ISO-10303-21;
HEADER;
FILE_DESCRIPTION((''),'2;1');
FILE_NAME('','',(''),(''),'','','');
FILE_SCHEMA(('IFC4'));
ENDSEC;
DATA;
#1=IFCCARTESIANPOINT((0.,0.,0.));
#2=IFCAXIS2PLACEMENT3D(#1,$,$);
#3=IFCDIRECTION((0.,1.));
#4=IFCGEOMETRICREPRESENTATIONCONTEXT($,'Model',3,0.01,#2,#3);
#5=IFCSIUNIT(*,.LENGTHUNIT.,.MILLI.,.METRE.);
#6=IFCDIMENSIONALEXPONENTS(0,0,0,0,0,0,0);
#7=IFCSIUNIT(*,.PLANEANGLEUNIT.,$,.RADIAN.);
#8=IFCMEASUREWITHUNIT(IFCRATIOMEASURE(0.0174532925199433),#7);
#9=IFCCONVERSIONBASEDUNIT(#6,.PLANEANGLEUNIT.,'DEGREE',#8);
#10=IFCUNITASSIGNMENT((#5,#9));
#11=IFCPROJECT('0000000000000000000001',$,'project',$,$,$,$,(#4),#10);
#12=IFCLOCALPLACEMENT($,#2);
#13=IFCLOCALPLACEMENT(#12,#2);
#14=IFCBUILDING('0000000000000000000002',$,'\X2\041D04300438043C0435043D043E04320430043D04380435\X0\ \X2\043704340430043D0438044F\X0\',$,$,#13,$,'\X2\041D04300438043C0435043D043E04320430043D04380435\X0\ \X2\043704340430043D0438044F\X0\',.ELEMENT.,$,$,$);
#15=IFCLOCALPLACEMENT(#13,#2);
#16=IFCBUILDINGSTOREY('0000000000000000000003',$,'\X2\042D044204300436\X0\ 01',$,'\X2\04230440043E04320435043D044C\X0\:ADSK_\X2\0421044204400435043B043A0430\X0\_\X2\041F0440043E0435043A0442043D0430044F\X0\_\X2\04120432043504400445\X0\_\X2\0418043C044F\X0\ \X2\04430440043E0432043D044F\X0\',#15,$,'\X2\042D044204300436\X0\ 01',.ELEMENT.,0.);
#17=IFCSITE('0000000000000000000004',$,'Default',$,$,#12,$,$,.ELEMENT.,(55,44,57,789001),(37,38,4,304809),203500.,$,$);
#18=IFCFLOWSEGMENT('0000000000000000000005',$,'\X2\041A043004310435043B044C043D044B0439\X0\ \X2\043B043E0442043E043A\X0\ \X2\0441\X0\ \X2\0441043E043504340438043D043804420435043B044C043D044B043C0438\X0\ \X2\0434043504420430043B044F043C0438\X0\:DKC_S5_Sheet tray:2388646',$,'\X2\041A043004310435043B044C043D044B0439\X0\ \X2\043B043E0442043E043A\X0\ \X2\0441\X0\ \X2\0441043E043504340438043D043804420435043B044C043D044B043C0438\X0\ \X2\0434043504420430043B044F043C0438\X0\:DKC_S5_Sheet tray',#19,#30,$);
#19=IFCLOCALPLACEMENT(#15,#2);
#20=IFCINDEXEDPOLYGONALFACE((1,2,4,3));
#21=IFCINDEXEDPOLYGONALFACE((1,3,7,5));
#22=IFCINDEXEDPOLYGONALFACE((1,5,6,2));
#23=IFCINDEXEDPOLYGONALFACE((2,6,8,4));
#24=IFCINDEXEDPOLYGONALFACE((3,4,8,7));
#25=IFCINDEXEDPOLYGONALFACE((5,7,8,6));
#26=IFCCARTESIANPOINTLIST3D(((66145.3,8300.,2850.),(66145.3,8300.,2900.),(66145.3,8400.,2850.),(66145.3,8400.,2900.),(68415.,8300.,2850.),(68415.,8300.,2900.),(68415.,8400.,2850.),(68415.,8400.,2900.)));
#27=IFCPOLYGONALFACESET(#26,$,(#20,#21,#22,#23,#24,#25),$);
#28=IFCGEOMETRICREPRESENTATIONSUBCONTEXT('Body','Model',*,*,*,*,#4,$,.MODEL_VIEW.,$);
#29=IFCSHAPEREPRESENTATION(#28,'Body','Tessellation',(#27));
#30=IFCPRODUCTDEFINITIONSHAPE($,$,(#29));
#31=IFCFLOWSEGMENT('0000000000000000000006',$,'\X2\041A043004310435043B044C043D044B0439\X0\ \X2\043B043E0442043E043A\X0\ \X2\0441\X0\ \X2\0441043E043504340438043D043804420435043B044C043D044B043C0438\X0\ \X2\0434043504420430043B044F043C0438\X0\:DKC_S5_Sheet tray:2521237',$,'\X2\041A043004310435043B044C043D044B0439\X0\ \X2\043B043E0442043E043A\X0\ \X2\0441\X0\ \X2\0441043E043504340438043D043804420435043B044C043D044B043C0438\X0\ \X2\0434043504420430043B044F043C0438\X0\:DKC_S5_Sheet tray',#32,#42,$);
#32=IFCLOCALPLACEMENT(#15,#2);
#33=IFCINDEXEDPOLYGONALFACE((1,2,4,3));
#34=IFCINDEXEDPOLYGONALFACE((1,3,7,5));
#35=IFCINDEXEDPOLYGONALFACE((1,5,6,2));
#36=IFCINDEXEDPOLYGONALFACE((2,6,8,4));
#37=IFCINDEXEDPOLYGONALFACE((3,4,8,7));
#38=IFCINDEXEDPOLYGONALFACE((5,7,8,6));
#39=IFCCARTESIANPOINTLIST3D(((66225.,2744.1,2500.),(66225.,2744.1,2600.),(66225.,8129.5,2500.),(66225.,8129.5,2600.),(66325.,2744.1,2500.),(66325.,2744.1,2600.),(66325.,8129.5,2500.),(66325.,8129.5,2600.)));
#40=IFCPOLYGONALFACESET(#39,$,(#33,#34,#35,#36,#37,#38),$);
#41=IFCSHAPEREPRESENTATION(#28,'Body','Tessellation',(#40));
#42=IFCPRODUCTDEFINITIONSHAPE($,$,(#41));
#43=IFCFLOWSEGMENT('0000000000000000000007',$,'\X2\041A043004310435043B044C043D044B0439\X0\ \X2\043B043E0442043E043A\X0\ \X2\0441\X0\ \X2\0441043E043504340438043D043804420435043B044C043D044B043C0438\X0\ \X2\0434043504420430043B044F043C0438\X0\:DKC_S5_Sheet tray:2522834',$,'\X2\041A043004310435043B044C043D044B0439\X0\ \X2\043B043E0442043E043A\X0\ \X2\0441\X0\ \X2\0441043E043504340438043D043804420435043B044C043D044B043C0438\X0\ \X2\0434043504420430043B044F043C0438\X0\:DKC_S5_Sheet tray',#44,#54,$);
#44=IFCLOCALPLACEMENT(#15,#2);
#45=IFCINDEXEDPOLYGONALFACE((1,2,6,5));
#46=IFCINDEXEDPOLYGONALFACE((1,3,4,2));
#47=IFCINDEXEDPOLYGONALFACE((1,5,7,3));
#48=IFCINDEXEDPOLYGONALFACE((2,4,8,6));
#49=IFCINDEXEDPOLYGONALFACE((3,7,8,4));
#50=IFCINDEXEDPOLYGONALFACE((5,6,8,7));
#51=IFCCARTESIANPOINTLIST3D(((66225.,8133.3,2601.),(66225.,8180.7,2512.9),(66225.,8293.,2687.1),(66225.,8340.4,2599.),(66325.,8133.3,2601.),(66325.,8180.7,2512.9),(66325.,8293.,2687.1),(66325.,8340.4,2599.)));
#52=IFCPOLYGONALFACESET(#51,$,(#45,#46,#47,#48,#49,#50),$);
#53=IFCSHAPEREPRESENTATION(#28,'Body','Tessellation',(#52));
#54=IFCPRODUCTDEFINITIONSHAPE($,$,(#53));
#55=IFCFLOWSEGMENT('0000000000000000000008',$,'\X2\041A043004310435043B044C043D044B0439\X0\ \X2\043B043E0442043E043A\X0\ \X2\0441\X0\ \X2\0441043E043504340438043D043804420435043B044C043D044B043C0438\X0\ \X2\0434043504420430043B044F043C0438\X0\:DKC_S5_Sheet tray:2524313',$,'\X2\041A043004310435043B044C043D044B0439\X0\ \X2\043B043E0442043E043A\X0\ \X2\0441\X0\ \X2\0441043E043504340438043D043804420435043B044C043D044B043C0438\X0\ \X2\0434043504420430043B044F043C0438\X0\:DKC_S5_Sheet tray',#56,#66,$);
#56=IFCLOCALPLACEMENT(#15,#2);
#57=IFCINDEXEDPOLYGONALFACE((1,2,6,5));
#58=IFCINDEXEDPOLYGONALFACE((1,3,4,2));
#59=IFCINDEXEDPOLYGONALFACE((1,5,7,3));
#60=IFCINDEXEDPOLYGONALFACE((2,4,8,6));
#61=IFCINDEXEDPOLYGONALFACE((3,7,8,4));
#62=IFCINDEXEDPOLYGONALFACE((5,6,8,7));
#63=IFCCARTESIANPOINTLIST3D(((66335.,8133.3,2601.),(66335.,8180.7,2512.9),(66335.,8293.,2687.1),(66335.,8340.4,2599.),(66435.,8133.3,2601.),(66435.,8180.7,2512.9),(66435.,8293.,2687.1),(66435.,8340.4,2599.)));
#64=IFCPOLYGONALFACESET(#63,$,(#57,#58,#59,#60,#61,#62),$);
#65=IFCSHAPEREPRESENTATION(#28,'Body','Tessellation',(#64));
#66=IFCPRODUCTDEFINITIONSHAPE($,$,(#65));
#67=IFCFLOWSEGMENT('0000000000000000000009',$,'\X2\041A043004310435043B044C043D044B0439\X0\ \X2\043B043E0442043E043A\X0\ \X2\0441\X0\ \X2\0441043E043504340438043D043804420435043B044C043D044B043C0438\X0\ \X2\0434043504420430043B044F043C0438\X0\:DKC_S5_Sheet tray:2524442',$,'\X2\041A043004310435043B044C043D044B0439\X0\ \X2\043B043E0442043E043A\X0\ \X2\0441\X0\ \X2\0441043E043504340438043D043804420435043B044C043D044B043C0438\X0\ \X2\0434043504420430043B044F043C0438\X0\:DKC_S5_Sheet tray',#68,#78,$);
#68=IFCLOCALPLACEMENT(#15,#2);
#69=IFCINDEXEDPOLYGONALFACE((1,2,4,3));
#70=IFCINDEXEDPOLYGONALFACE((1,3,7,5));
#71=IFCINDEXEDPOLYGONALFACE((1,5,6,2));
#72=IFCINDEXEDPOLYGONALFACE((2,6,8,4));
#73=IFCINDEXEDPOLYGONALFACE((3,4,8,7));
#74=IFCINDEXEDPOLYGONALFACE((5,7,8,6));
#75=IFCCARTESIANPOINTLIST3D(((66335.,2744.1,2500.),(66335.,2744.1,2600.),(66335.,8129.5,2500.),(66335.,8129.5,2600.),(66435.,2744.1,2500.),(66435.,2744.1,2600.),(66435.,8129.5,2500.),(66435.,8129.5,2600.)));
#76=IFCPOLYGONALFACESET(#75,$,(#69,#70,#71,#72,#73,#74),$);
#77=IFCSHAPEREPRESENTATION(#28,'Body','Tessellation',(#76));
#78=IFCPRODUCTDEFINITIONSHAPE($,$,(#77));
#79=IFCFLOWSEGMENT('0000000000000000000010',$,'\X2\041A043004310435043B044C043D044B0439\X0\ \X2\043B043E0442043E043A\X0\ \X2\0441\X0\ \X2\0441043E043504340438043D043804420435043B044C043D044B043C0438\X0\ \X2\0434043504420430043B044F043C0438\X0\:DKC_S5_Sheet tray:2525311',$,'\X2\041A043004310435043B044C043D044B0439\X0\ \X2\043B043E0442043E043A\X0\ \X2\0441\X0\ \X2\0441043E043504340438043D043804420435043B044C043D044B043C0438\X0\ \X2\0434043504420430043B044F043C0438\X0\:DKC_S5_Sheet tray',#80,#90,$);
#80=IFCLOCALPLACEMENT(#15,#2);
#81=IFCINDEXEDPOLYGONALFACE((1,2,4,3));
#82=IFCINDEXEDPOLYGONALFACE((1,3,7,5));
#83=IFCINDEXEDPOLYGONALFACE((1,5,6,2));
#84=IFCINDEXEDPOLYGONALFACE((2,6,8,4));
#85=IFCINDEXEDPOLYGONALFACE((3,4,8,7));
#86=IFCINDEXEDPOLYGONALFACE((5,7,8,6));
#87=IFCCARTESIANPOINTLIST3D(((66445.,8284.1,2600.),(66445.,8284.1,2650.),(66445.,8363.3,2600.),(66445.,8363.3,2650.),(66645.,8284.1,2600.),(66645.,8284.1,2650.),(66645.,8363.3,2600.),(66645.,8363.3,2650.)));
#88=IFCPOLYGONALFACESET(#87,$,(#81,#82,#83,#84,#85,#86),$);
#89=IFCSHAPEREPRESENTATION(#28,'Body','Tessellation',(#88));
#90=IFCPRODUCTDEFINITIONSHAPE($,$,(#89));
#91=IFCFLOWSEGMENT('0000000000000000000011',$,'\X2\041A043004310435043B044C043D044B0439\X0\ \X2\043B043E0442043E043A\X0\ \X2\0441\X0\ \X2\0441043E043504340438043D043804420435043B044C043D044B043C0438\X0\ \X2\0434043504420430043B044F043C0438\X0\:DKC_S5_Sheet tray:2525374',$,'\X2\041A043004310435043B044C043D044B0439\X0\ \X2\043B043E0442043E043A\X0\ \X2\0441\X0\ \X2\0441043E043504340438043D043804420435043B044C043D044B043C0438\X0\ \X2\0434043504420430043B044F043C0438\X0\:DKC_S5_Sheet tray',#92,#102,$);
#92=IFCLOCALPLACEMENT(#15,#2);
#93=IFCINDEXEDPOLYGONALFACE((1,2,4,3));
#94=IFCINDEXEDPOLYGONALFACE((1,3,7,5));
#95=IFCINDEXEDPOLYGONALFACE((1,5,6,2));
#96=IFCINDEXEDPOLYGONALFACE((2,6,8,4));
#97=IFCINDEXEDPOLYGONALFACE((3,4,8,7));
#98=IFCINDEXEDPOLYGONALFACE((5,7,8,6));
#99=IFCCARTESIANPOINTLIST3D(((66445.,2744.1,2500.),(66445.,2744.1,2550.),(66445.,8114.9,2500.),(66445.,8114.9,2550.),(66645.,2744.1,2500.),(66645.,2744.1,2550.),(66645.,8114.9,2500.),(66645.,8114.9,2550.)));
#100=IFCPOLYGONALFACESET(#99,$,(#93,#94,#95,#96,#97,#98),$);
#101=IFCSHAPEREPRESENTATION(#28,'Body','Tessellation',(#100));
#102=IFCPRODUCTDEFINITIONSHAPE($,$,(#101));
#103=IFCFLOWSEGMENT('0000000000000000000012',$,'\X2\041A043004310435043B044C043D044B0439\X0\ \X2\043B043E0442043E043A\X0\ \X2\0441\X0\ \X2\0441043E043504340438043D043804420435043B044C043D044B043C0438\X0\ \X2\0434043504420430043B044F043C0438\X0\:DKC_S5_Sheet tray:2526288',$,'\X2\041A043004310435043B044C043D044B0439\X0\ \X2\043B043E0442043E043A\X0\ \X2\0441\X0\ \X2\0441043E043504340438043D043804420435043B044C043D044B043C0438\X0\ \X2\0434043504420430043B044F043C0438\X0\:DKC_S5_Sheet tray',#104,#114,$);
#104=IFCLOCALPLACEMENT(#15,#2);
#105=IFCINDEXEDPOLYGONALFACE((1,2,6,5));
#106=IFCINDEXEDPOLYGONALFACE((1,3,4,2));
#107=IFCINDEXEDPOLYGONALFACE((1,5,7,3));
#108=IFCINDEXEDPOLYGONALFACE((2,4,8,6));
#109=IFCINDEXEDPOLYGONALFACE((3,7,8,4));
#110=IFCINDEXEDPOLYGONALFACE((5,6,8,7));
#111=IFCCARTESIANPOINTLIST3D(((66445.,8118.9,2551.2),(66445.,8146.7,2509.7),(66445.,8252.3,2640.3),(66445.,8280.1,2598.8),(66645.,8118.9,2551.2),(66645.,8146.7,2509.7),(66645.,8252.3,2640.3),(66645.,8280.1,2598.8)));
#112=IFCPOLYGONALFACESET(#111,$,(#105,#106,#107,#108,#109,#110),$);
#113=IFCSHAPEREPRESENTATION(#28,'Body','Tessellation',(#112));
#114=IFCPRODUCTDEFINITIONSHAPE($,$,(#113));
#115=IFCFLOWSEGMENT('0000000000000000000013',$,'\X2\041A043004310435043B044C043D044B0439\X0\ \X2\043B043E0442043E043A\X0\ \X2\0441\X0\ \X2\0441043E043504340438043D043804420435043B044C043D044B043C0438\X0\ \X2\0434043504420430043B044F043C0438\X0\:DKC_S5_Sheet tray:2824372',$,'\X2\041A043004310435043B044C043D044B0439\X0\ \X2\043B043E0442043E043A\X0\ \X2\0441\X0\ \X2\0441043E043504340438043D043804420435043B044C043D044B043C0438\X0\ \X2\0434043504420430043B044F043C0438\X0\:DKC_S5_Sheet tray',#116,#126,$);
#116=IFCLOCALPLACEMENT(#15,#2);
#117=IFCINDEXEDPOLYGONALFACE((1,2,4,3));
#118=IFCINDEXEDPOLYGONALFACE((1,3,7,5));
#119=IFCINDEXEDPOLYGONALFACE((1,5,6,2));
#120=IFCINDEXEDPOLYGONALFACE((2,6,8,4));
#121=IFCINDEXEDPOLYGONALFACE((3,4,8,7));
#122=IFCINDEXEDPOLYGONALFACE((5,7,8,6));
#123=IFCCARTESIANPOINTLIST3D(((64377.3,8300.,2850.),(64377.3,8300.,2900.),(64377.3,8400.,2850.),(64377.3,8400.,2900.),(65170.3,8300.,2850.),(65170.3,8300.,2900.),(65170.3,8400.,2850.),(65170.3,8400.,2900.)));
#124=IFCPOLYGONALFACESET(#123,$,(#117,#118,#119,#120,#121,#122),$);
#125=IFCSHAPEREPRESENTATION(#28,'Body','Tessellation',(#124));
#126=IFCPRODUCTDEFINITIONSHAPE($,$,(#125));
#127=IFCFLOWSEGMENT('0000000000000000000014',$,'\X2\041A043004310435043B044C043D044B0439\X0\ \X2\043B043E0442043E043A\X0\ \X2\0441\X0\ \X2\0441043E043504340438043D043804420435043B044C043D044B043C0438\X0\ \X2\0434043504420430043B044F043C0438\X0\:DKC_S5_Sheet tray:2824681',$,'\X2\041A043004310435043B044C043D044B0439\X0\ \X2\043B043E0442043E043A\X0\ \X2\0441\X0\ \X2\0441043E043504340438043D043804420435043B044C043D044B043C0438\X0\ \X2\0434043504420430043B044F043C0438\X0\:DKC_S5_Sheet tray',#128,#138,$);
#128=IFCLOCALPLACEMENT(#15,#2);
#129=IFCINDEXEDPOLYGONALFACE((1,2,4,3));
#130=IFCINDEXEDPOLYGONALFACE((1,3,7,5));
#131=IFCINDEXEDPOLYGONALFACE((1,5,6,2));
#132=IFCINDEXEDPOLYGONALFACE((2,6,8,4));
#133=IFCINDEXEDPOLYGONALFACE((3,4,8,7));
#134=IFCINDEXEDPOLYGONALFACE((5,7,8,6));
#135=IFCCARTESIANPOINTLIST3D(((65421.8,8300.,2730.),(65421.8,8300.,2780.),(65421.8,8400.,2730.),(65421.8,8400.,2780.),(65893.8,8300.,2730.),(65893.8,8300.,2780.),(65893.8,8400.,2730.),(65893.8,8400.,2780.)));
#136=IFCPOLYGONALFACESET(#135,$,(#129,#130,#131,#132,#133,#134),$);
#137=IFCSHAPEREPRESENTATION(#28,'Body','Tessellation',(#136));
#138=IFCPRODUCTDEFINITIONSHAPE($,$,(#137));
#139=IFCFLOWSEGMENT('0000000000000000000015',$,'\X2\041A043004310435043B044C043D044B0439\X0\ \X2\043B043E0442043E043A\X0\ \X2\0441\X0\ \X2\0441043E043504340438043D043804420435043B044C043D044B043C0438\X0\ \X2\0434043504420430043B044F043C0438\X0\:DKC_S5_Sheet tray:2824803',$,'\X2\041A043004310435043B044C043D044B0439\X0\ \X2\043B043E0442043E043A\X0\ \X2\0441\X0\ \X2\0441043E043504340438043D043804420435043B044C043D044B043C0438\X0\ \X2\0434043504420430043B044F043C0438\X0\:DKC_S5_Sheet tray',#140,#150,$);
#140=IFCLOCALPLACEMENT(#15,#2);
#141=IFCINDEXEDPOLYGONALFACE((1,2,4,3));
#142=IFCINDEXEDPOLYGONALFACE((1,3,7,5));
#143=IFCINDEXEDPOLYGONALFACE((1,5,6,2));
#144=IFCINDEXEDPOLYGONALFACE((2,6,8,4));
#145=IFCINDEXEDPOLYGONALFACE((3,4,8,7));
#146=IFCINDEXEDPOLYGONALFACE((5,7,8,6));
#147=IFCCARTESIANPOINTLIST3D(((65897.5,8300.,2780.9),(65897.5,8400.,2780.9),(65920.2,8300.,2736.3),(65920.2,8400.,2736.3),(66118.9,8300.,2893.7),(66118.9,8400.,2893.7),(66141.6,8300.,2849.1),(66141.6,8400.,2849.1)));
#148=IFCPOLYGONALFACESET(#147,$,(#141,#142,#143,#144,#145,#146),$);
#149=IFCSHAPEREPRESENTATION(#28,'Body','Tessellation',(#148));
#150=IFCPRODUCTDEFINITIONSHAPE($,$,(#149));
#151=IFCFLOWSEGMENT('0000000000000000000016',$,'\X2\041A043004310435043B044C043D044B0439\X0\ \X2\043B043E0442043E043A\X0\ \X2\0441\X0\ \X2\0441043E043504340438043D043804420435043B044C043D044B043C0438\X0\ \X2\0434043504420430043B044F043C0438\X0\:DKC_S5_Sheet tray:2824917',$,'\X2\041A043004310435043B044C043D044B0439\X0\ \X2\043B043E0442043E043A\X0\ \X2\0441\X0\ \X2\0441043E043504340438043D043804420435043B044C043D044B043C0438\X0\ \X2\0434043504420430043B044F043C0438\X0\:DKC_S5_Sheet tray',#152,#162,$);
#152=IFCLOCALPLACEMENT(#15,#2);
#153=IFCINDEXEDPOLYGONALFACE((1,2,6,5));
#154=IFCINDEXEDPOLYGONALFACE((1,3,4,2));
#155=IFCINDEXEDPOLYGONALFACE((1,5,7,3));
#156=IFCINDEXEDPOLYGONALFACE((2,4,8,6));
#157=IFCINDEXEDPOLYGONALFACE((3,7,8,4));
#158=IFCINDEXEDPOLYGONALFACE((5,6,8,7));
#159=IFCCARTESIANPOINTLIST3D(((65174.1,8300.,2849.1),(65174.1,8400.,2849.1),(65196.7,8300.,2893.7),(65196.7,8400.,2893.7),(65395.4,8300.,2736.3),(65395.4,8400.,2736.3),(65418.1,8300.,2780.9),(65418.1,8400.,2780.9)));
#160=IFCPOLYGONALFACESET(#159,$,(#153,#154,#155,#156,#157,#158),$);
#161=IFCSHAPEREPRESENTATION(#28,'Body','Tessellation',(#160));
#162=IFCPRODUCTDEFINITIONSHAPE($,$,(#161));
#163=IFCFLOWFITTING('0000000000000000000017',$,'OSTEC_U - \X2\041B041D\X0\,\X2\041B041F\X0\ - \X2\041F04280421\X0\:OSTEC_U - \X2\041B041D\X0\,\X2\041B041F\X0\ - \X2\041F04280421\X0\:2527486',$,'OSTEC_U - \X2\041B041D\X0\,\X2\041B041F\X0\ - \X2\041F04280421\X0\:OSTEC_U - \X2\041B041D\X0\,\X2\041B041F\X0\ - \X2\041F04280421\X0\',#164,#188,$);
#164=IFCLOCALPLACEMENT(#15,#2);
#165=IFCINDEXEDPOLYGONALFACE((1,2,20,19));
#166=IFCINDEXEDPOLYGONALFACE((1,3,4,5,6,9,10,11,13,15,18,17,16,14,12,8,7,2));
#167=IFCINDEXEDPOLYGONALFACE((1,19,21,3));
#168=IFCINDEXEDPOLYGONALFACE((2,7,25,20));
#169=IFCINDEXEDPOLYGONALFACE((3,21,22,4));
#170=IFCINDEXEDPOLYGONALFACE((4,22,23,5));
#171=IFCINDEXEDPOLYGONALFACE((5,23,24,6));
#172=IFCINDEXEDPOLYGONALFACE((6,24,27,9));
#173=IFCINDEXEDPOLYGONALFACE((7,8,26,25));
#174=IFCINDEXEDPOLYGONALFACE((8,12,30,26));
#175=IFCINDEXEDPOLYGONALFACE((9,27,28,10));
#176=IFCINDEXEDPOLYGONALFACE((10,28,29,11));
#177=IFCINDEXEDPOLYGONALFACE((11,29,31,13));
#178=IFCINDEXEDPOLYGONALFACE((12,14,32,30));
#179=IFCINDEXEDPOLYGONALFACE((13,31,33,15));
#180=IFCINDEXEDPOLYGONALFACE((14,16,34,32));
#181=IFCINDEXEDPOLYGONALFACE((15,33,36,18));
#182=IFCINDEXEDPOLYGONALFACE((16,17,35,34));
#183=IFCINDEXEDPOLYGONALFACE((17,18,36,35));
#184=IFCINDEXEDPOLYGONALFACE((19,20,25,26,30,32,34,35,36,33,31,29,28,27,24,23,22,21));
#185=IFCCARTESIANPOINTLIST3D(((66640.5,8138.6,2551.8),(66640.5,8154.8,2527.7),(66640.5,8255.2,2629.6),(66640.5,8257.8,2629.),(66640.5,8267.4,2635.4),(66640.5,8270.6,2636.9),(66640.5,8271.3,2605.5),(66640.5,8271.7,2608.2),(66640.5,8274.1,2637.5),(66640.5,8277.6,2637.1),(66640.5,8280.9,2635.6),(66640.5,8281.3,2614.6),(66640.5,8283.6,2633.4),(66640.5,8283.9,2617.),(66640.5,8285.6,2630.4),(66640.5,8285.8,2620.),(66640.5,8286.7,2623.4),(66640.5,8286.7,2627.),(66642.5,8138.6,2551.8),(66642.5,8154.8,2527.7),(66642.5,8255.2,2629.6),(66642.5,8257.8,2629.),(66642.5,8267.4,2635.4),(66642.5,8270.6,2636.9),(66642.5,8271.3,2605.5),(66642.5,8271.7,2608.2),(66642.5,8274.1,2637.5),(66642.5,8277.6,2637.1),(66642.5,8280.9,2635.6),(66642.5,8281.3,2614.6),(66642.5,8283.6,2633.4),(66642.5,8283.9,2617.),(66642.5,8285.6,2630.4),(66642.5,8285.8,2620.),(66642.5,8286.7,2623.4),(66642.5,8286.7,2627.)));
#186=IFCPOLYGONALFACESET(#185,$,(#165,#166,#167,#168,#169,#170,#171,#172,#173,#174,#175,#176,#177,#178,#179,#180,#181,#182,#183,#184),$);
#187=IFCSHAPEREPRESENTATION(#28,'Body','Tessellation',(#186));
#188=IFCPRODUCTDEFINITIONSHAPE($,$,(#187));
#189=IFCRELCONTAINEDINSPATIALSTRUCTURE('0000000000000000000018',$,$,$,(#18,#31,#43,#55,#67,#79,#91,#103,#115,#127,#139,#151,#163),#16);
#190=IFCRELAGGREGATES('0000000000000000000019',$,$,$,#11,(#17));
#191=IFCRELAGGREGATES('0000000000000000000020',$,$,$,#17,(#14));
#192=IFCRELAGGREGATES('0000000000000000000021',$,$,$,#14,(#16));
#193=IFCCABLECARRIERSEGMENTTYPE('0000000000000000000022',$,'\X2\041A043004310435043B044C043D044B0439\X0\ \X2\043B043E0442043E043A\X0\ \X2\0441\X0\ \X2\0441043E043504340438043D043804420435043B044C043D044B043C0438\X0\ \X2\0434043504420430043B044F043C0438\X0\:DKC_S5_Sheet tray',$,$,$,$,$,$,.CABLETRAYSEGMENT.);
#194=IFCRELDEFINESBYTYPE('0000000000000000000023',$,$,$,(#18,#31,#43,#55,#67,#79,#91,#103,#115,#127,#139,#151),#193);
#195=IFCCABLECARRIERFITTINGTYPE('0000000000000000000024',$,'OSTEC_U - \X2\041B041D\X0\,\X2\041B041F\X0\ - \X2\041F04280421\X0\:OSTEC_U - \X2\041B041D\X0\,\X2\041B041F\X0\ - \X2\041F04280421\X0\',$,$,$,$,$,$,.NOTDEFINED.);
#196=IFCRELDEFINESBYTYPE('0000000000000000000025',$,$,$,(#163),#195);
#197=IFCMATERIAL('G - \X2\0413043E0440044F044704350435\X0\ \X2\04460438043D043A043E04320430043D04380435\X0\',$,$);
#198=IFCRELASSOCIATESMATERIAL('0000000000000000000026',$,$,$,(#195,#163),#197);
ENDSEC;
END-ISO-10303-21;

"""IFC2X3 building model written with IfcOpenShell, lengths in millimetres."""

from ifc_helpers import new_model, entity, si_unit, converted_unit, direction, frame, frame_2d, origin, origin_2d_with_axis, place, context, subcontext, project, spatial, polyline, circle_curve, parameter, trimmed, segment, composite_curve, rectangle, outline, extrude, source, transform, mapped, material, type_object, type_shapes, element, save


model = new_model("IFC2X3")

# Units and contexts
model_context = context("Model", 3, precision=0.01, world=origin(), true_north=direction((0.0, 1.0)))
body_context = subcontext(model_context, "Body", "Model", "MODEL_VIEW")
ifc_project = project(units=[si_unit("LENGTHUNIT", "METRE", prefix="MILLI"), converted_unit("PLANEANGLEUNIT", "DEGREE", entity("IfcRatioMeasure", 0.0174532925199433), si_unit("PLANEANGLEUNIT", "RADIAN"), dimensions=[0, 0, 0, 0, 0, 0, 0])], contexts=[model_context])

# Site, building, storey
site_placement = place(None, origin())
site = spatial("IfcSite", under=ifc_project, at=site_placement, Name="Default", CompositionType="ELEMENT", RefLatitude=(55, 44, 57, 789001), RefLongitude=(37, 38, 4, 304809), RefElevation=203500.0)
building_placement = place(site_placement, origin())
building = spatial("IfcBuilding", under=site, at=building_placement, Name="Наименование здания", LongName="Наименование здания", CompositionType="ELEMENT")
storey_placement = place(building_placement, origin())
storey = spatial("IfcBuildingStorey", under=building, at=storey_placement, Name="Этаж 01", ObjectType="Уровень:ADSK_Стрелка_Проектная_Вверх_Имя уровня", LongName="Этаж 01", CompositionType="ELEMENT", Elevation=0.0)

# Flow segments
cable_carrier_segment_type = type_object("IfcCableCarrierSegmentType", Name="Кабельный лоток с соединительными деталями:DKC_S5_Sheet tray", PredefinedType="CABLETRAYSEGMENT")
flow_segment_1_placement = place(storey_placement, frame((66145.3, 8300.0, 2850.0)))
element("IfcFlowSegment", 1, at=flow_segment_1_placement, inside=storey, type_object=cable_carrier_segment_type, Name="Кабельный лоток с соединительными деталями:DKC_S5_Sheet tray:2388646", ObjectType="Кабельный лоток с соединительными деталями:DKC_S5_Sheet tray", context=body_context, shape_type="SweptSolid", body=[
    extrude(rectangle(XDim=2269.8, YDim=100.0, at=origin_2d_with_axis()), frame((1134.9, 50.0, 0.0), z_axis=(0.0, 0.0, 1.0), x_axis=(-1.0, 0.0, 0.0)), (0.0, 0.0, 1.0), 50.0),
])
flow_segment_2_placement = place(storey_placement, frame((66225.0, 2744.1, 2500.0)))
element("IfcFlowSegment", 2, at=flow_segment_2_placement, inside=storey, type_object=cable_carrier_segment_type, Name="Кабельный лоток с соединительными деталями:DKC_S5_Sheet tray:2521237", ObjectType="Кабельный лоток с соединительными деталями:DKC_S5_Sheet tray", context=body_context, shape_type="SweptSolid", body=[
    extrude(rectangle(XDim=5385.4, YDim=100.0, at=origin_2d_with_axis()), frame((50.0, 2692.7, 0.0), z_axis=(0.0, 0.0, 1.0), x_axis=(0.0, -1.0, 0.0)), (0.0, 0.0, 1.0), 100.0),
])
flow_segment_3_placement = place(storey_placement, frame((66225.0, 8133.3, 2512.9)))
element("IfcFlowSegment", 3, at=flow_segment_3_placement, inside=storey, type_object=cable_carrier_segment_type, Name="Кабельный лоток с соединительными деталями:DKC_S5_Sheet tray:2522834", ObjectType="Кабельный лоток с соединительными деталями:DKC_S5_Sheet tray", context=body_context, shape_type="SweptSolid", body=[
    extrude(rectangle(XDim=100.0, YDim=100.0, at=origin_2d_with_axis()), frame((50.0, 23.7, 44.0), z_axis=(0.0, 0.880203, 0.474598), x_axis=(0.0, -0.474598, 0.880203)), (0.0, 0.0, 1.0), 181.4),
])
flow_segment_4_placement = place(storey_placement, frame((66335.0, 8133.3, 2512.9)))
element("IfcFlowSegment", 4, at=flow_segment_4_placement, inside=storey, type_object=cable_carrier_segment_type, Name="Кабельный лоток с соединительными деталями:DKC_S5_Sheet tray:2524313", ObjectType="Кабельный лоток с соединительными деталями:DKC_S5_Sheet tray", context=body_context, shape_type="SweptSolid", body=[
    extrude(rectangle(XDim=100.0, YDim=100.0, at=origin_2d_with_axis()), frame((50.0, 23.7, 44.0), z_axis=(0.0, 0.880203, 0.474598), x_axis=(0.0, -0.474598, 0.880203)), (0.0, 0.0, 1.0), 181.4),
])
flow_segment_5_placement = place(storey_placement, frame((66335.0, 2744.1, 2500.0)))
element("IfcFlowSegment", 5, at=flow_segment_5_placement, inside=storey, type_object=cable_carrier_segment_type, Name="Кабельный лоток с соединительными деталями:DKC_S5_Sheet tray:2524442", ObjectType="Кабельный лоток с соединительными деталями:DKC_S5_Sheet tray", context=body_context, shape_type="SweptSolid", body=[
    extrude(rectangle(XDim=5385.4, YDim=100.0, at=origin_2d_with_axis()), frame((50.0, 2692.7, 0.0), z_axis=(0.0, 0.0, 1.0), x_axis=(0.0, -1.0, 0.0)), (0.0, 0.0, 1.0), 100.0),
])
flow_segment_6_placement = place(storey_placement, frame((66445.0, 8284.1, 2600.0)))
element("IfcFlowSegment", 6, at=flow_segment_6_placement, inside=storey, type_object=cable_carrier_segment_type, Name="Кабельный лоток с соединительными деталями:DKC_S5_Sheet tray:2525311", ObjectType="Кабельный лоток с соединительными деталями:DKC_S5_Sheet tray", context=body_context, shape_type="SweptSolid", body=[
    extrude(rectangle(XDim=79.2, YDim=200.0, at=origin_2d_with_axis()), frame((100.0, 39.6, 0.0), z_axis=(0.0, 0.0, 1.0), x_axis=(0.0, -1.0, 0.0)), (0.0, 0.0, 1.0), 50.0),
])
flow_segment_7_placement = place(storey_placement, frame((66445.0, 2744.1, 2500.0)))
element("IfcFlowSegment", 7, at=flow_segment_7_placement, inside=storey, type_object=cable_carrier_segment_type, Name="Кабельный лоток с соединительными деталями:DKC_S5_Sheet tray:2525374", ObjectType="Кабельный лоток с соединительными деталями:DKC_S5_Sheet tray", context=body_context, shape_type="SweptSolid", body=[
    extrude(rectangle(XDim=5370.7, YDim=200.0, at=origin_2d_with_axis()), frame((100.0, 2685.4, 0.0), z_axis=(0.0, 0.0, 1.0), x_axis=(0.0, -1.0, 0.0)), (0.0, 0.0, 1.0), 50.0),
])
flow_segment_8_placement = place(storey_placement, frame((66445.0, 8118.9, 2509.7)))
element("IfcFlowSegment", 8, at=flow_segment_8_placement, inside=storey, type_object=cable_carrier_segment_type, Name="Кабельный лоток с соединительными деталями:DKC_S5_Sheet tray:2526288", ObjectType="Кабельный лоток с соединительными деталями:DKC_S5_Sheet tray", context=body_context, shape_type="SweptSolid", body=[
    extrude(rectangle(XDim=50.0, YDim=160.4, at=frame_2d((0.0, 0.0), x_axis=(0.0, 1.0))), frame((0.0, 80.6, 65.3), z_axis=(1.0, 0.0, 0.0), x_axis=(0.0, -0.831467, -0.555575)), (0.0, 0.0, 1.0), 200.0),
])
flow_segment_9_placement = place(storey_placement, frame((64377.3, 8300.0, 2850.0)))
element("IfcFlowSegment", 9, at=flow_segment_9_placement, inside=storey, type_object=cable_carrier_segment_type, Name="Кабельный лоток с соединительными деталями:DKC_S5_Sheet tray:2824372", ObjectType="Кабельный лоток с соединительными деталями:DKC_S5_Sheet tray", context=body_context, shape_type="SweptSolid", body=[
    extrude(rectangle(XDim=793.0, YDim=100.0, at=origin_2d_with_axis()), frame((396.5, 50.0, 0.0)), (0.0, 0.0, 1.0), 50.0),
])
flow_segment_10_placement = place(storey_placement, frame((65421.8, 8300.0, 2730.0)))
element("IfcFlowSegment", 10, at=flow_segment_10_placement, inside=storey, type_object=cable_carrier_segment_type, Name="Кабельный лоток с соединительными деталями:DKC_S5_Sheet tray:2824681", ObjectType="Кабельный лоток с соединительными деталями:DKC_S5_Sheet tray", context=body_context, shape_type="SweptSolid", body=[
    extrude(rectangle(XDim=472.0, YDim=100.0, at=origin_2d_with_axis()), frame((236.0, 50.0, 0.0), z_axis=(0.0, 0.0, 1.0), x_axis=(-1.0, 0.0, 0.0)), (0.0, 0.0, 1.0), 50.0),
])
flow_segment_11_placement = place(storey_placement, frame((65897.5, 8300.0, 2736.3)))
element("IfcFlowSegment", 11, at=flow_segment_11_placement, inside=storey, type_object=cable_carrier_segment_type, Name="Кабельный лоток с соединительными деталями:DKC_S5_Sheet tray:2824803", ObjectType="Кабельный лоток с соединительными деталями:DKC_S5_Sheet tray", context=body_context, shape_type="SweptSolid", body=[
    extrude(rectangle(XDim=50.0, YDim=100.0, at=frame_2d((0.0, 0.0), x_axis=(0.0, 1.0))), frame((11.3, 50.0, 22.3), z_axis=(0.891007, 0.0, 0.45399), x_axis=(0.0, 1.0, 0.0)), (0.0, 0.0, 1.0), 248.4),
])
flow_segment_12_placement = place(storey_placement, frame((65174.1, 8300.0, 2736.3)))
element("IfcFlowSegment", 12, at=flow_segment_12_placement, inside=storey, type_object=cable_carrier_segment_type, Name="Кабельный лоток с соединительными деталями:DKC_S5_Sheet tray:2824917", ObjectType="Кабельный лоток с соединительными деталями:DKC_S5_Sheet tray", context=body_context, shape_type="SweptSolid", body=[
    extrude(rectangle(XDim=50.0, YDim=100.0, at=origin_2d_with_axis()), frame((11.3, 50.0, 135.1), z_axis=(0.891007, 0.0, -0.45399), x_axis=(0.45399, 0.0, 0.891007)), (0.0, 0.0, 1.0), 248.4),
])

# Flow fitting
ifc_material = material(Name="G - Горячее цинкование")
cable_carrier_fitting_type_1 = type_object("IfcCableCarrierFittingType", Name="OSTEC_U - ЛН,ЛП - ПШС:OSTEC_U - ЛН,ЛП - ПШС", PredefinedType="NOTDEFINED", material=ifc_material)
shared_shape_1 = source(origin(), body_context, "Body", "SweptSolid", [
    extrude(outline(composite_curve([segment(trimmed(circle_curve(frame_2d((-44.6, 0.0), x_axis=(1.0, 0.0)), 12.5), [parameter(90.0)], [parameter(270.0)], True, "PARAMETER"), True, "CONTINUOUS"), segment(polyline([(-44.6, -12.5), (-33.1, -12.5)]), True, "CONTINUOUS"), segment(polyline([(-33.1, -12.5), (-31.2, -14.5)]), True, "CONTINUOUS"), segment(polyline([(-31.2, -14.5), (108.9, -14.5)]), True, "CONTINUOUS"), segment(polyline([(108.9, -14.5), (108.9, 14.5)]), True, "CONTINUOUS"), segment(polyline([(108.9, 14.5), (-31.2, 14.5)]), True, "CONTINUOUS"), segment(polyline([(-31.2, 14.5), (-33.1, 12.5)]), True, "CONTINUOUS"), segment(polyline([(-33.1, 12.5), (-44.6, 12.5)]), True, "CONTINUOUS")], self_intersect=False)), frame((44.6, 0.0, 0.0), z_axis=(0.0, 0.0, -1.0), x_axis=(1.0, 0.0, 0.0)), (0.0, 0.0, -1.0), 2.0),
])
type_shapes(cable_carrier_fitting_type_1, [shared_shape_1])
flow_fitting_1_placement = place(storey_placement, frame((66640.5, 8274.3, 2625.0), z_axis=(1.0, 0.0, 0.0), x_axis=(0.0, -0.831467, -0.555575)))
element("IfcFlowFitting", 13, at=flow_fitting_1_placement, inside=storey, type_object=cable_carrier_fitting_type_1, material=ifc_material, Name="OSTEC_U - ЛН,ЛП - ПШС:OSTEC_U - ЛН,ЛП - ПШС:2527486", ObjectType="OSTEC_U - ЛН,ЛП - ПШС:OSTEC_U - ЛН,ЛП - ПШС", context=body_context, shape_type="MappedRepresentation", body=[
    mapped(shared_shape_1, transform((0.0, 0.0, 0.0), scale=1.0)),
])

save(model, "model.ifc")
